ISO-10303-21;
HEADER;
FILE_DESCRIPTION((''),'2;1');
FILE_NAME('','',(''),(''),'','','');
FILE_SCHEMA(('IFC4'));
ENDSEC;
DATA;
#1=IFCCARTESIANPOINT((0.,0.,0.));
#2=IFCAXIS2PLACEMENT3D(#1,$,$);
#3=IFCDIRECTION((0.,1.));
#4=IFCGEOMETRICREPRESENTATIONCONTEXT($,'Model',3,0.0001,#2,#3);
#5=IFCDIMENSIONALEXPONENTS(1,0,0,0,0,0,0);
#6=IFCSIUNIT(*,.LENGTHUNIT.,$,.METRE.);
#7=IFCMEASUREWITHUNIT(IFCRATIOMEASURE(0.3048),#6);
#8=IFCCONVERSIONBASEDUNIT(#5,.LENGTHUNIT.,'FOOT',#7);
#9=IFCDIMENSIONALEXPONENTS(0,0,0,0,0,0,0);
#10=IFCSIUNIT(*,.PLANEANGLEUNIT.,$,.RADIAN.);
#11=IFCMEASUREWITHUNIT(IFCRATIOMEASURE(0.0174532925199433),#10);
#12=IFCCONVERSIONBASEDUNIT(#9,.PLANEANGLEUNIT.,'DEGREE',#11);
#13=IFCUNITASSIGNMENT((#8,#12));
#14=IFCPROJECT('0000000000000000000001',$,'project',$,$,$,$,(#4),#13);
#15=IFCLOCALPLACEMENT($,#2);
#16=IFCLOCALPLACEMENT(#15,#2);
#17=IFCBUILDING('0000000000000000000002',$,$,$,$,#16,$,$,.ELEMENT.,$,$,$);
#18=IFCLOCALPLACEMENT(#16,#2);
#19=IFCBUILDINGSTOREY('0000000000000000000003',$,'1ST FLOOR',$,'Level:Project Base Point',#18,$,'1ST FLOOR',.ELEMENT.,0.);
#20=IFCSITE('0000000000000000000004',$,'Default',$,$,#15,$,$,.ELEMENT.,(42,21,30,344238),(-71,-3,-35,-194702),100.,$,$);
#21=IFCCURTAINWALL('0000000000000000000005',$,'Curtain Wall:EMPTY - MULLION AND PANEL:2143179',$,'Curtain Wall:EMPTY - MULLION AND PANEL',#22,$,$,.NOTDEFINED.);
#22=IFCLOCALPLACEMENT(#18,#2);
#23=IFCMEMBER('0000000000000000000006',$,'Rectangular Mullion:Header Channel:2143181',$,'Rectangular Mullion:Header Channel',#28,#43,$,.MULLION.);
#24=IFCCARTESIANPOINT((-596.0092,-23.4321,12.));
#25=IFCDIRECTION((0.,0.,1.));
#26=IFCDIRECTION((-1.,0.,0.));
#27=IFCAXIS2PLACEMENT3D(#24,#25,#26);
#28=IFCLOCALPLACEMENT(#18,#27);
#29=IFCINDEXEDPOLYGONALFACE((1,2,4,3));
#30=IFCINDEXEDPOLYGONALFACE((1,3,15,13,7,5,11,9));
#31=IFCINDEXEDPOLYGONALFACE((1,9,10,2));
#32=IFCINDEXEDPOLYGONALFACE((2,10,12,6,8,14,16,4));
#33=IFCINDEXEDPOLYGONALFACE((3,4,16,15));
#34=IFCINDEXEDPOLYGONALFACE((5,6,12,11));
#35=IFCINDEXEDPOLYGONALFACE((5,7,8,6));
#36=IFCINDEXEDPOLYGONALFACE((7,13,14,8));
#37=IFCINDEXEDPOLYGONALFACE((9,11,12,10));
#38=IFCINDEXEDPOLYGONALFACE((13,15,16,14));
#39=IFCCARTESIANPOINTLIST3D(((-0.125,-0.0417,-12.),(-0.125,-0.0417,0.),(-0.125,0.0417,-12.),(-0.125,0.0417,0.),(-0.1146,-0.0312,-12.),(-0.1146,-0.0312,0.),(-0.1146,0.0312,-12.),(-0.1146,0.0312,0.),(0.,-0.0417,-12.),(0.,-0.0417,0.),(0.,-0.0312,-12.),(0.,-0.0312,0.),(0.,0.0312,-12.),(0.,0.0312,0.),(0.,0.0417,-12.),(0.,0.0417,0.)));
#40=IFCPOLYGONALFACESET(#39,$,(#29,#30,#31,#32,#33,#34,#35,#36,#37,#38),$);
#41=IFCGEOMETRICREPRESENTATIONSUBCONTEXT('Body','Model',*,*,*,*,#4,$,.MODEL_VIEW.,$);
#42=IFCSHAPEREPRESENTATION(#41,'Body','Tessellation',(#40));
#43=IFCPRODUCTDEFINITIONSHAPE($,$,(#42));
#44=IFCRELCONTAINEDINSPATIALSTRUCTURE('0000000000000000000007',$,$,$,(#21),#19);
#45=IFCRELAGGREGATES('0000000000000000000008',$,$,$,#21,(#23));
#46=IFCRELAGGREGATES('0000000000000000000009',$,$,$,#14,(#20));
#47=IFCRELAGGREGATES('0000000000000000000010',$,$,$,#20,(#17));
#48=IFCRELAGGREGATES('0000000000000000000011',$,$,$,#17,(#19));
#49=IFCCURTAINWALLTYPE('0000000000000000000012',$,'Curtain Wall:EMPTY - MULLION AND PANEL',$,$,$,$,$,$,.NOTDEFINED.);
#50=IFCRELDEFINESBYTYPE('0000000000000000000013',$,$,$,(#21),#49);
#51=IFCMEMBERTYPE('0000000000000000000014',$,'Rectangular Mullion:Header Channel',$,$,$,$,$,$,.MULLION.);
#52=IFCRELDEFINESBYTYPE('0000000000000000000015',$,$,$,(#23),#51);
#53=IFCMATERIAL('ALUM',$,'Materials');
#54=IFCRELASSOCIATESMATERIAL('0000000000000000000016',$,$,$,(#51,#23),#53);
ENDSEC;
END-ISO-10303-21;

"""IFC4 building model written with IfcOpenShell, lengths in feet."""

from ifc_helpers import new_model, entity, si_unit, converted_unit, direction, frame, origin, place, context, subcontext, project, spatial, polyline, outline, extrude, source, transform, mapped, material, material_profile, profile_set, profile_usage, type_object, type_shapes, element, aggregate, save


model = new_model("IFC4")

# Units and contexts
model_context = context("Model", 3, precision=0.0001, world=origin(), true_north=direction((0.0, 1.0)))
body_context = subcontext(model_context, "Body", "Model", "MODEL_VIEW")
ifc_project = project(units=[converted_unit("LENGTHUNIT", "FOOT", entity("IfcRatioMeasure", 0.3048), si_unit("LENGTHUNIT", "METRE"), dimensions=[1, 0, 0, 0, 0, 0, 0]), converted_unit("PLANEANGLEUNIT", "DEGREE", entity("IfcRatioMeasure", 0.0174532925199433), si_unit("PLANEANGLEUNIT", "RADIAN"), dimensions=[0, 0, 0, 0, 0, 0, 0])], contexts=[model_context])

# Site, building, storey
site_placement = place(None, origin())
site = spatial("IfcSite", under=ifc_project, at=site_placement, Name="Default", CompositionType="ELEMENT", RefLatitude=(42, 21, 30, 344238), RefLongitude=(-71, -3, -35, -194702), RefElevation=100.0)
building_placement = place(site_placement, origin())
building = spatial("IfcBuilding", under=site, at=building_placement, CompositionType="ELEMENT")
storey_placement = place(building_placement, origin())
storey = spatial("IfcBuildingStorey", under=building, at=storey_placement, Name="1ST FLOOR", ObjectType="Level:Project Base Point", LongName="1ST FLOOR", CompositionType="ELEMENT", Elevation=0.0)

# Curtain wall, member
curtain_wall_type = type_object("IfcCurtainWallType", Name="Curtain Wall:EMPTY - MULLION AND PANEL", PredefinedType="NOTDEFINED")
ifc_material_1 = material(Name="ALUM", Category="Materials")
curtain_wall_1_placement = place(storey_placement, origin())
curtain_wall_1 = element("IfcCurtainWall", 1, at=curtain_wall_1_placement, inside=storey, type_object=curtain_wall_type, Name="Curtain Wall:EMPTY - MULLION AND PANEL:2143179", ObjectType="Curtain Wall:EMPTY - MULLION AND PANEL", PredefinedType="NOTDEFINED")
ifc_material_profile_1 = material_profile(ifc_material_1, outline(polyline([(-0.0417, -0.0599), (-0.0313, -0.0599), (-0.0312, 0.0547), (0.0313, 0.0547), (0.0312, -0.0599), (0.0417, -0.0599), (0.0417, 0.0651), (-0.0417, 0.0651), (-0.0417, -0.0599)])), Name="Header Channel")
ifc_profile_set_1 = profile_set([ifc_material_profile_1], Name="Header Channel")
ifc_profile_usage_1 = profile_usage(ifc_profile_set_1)
member_type_1 = type_object("IfcMemberType", Name="Rectangular Mullion:Header Channel", PredefinedType="MULLION", material=ifc_profile_set_1)
shared_shape_1 = source(origin(), body_context, "Body", "SweptSolid", [
    extrude(outline(polyline([(-0.0417, -0.0651), (0.0417, -0.0651), (0.0417, 0.0599), (0.0312, 0.0599), (0.0312, -0.0547), (-0.0312, -0.0547), (-0.0312, 0.0599), (-0.0417, 0.0599), (-0.0417, -0.0651)])), frame((-0.0599, 0.0, -12.0), z_axis=(0.0, 0.0, 1.0), x_axis=(0.0, -1.0, 0.0)), (0.0, 0.0, 1.0), 12.0),
])
type_shapes(member_type_1, [shared_shape_1])
member_1_placement = place(storey_placement, frame((-596.0092, -23.4321, 12.0), z_axis=(0.0, 0.0, 1.0), x_axis=(-1.0, 0.0, 0.0)))
member_1 = element("IfcMember", 2, at=member_1_placement, type_object=member_type_1, material=ifc_profile_usage_1, Name="Rectangular Mullion:Header Channel:2143181", ObjectType="Rectangular Mullion:Header Channel", PredefinedType="MULLION", context=body_context, shape_type="MappedRepresentation", body=[
    mapped(shared_shape_1, transform((0.0, 0.0, 0.0), scale=1.0)),
])
aggregate(curtain_wall_1, [member_1])

save(model, "model.ifc")
